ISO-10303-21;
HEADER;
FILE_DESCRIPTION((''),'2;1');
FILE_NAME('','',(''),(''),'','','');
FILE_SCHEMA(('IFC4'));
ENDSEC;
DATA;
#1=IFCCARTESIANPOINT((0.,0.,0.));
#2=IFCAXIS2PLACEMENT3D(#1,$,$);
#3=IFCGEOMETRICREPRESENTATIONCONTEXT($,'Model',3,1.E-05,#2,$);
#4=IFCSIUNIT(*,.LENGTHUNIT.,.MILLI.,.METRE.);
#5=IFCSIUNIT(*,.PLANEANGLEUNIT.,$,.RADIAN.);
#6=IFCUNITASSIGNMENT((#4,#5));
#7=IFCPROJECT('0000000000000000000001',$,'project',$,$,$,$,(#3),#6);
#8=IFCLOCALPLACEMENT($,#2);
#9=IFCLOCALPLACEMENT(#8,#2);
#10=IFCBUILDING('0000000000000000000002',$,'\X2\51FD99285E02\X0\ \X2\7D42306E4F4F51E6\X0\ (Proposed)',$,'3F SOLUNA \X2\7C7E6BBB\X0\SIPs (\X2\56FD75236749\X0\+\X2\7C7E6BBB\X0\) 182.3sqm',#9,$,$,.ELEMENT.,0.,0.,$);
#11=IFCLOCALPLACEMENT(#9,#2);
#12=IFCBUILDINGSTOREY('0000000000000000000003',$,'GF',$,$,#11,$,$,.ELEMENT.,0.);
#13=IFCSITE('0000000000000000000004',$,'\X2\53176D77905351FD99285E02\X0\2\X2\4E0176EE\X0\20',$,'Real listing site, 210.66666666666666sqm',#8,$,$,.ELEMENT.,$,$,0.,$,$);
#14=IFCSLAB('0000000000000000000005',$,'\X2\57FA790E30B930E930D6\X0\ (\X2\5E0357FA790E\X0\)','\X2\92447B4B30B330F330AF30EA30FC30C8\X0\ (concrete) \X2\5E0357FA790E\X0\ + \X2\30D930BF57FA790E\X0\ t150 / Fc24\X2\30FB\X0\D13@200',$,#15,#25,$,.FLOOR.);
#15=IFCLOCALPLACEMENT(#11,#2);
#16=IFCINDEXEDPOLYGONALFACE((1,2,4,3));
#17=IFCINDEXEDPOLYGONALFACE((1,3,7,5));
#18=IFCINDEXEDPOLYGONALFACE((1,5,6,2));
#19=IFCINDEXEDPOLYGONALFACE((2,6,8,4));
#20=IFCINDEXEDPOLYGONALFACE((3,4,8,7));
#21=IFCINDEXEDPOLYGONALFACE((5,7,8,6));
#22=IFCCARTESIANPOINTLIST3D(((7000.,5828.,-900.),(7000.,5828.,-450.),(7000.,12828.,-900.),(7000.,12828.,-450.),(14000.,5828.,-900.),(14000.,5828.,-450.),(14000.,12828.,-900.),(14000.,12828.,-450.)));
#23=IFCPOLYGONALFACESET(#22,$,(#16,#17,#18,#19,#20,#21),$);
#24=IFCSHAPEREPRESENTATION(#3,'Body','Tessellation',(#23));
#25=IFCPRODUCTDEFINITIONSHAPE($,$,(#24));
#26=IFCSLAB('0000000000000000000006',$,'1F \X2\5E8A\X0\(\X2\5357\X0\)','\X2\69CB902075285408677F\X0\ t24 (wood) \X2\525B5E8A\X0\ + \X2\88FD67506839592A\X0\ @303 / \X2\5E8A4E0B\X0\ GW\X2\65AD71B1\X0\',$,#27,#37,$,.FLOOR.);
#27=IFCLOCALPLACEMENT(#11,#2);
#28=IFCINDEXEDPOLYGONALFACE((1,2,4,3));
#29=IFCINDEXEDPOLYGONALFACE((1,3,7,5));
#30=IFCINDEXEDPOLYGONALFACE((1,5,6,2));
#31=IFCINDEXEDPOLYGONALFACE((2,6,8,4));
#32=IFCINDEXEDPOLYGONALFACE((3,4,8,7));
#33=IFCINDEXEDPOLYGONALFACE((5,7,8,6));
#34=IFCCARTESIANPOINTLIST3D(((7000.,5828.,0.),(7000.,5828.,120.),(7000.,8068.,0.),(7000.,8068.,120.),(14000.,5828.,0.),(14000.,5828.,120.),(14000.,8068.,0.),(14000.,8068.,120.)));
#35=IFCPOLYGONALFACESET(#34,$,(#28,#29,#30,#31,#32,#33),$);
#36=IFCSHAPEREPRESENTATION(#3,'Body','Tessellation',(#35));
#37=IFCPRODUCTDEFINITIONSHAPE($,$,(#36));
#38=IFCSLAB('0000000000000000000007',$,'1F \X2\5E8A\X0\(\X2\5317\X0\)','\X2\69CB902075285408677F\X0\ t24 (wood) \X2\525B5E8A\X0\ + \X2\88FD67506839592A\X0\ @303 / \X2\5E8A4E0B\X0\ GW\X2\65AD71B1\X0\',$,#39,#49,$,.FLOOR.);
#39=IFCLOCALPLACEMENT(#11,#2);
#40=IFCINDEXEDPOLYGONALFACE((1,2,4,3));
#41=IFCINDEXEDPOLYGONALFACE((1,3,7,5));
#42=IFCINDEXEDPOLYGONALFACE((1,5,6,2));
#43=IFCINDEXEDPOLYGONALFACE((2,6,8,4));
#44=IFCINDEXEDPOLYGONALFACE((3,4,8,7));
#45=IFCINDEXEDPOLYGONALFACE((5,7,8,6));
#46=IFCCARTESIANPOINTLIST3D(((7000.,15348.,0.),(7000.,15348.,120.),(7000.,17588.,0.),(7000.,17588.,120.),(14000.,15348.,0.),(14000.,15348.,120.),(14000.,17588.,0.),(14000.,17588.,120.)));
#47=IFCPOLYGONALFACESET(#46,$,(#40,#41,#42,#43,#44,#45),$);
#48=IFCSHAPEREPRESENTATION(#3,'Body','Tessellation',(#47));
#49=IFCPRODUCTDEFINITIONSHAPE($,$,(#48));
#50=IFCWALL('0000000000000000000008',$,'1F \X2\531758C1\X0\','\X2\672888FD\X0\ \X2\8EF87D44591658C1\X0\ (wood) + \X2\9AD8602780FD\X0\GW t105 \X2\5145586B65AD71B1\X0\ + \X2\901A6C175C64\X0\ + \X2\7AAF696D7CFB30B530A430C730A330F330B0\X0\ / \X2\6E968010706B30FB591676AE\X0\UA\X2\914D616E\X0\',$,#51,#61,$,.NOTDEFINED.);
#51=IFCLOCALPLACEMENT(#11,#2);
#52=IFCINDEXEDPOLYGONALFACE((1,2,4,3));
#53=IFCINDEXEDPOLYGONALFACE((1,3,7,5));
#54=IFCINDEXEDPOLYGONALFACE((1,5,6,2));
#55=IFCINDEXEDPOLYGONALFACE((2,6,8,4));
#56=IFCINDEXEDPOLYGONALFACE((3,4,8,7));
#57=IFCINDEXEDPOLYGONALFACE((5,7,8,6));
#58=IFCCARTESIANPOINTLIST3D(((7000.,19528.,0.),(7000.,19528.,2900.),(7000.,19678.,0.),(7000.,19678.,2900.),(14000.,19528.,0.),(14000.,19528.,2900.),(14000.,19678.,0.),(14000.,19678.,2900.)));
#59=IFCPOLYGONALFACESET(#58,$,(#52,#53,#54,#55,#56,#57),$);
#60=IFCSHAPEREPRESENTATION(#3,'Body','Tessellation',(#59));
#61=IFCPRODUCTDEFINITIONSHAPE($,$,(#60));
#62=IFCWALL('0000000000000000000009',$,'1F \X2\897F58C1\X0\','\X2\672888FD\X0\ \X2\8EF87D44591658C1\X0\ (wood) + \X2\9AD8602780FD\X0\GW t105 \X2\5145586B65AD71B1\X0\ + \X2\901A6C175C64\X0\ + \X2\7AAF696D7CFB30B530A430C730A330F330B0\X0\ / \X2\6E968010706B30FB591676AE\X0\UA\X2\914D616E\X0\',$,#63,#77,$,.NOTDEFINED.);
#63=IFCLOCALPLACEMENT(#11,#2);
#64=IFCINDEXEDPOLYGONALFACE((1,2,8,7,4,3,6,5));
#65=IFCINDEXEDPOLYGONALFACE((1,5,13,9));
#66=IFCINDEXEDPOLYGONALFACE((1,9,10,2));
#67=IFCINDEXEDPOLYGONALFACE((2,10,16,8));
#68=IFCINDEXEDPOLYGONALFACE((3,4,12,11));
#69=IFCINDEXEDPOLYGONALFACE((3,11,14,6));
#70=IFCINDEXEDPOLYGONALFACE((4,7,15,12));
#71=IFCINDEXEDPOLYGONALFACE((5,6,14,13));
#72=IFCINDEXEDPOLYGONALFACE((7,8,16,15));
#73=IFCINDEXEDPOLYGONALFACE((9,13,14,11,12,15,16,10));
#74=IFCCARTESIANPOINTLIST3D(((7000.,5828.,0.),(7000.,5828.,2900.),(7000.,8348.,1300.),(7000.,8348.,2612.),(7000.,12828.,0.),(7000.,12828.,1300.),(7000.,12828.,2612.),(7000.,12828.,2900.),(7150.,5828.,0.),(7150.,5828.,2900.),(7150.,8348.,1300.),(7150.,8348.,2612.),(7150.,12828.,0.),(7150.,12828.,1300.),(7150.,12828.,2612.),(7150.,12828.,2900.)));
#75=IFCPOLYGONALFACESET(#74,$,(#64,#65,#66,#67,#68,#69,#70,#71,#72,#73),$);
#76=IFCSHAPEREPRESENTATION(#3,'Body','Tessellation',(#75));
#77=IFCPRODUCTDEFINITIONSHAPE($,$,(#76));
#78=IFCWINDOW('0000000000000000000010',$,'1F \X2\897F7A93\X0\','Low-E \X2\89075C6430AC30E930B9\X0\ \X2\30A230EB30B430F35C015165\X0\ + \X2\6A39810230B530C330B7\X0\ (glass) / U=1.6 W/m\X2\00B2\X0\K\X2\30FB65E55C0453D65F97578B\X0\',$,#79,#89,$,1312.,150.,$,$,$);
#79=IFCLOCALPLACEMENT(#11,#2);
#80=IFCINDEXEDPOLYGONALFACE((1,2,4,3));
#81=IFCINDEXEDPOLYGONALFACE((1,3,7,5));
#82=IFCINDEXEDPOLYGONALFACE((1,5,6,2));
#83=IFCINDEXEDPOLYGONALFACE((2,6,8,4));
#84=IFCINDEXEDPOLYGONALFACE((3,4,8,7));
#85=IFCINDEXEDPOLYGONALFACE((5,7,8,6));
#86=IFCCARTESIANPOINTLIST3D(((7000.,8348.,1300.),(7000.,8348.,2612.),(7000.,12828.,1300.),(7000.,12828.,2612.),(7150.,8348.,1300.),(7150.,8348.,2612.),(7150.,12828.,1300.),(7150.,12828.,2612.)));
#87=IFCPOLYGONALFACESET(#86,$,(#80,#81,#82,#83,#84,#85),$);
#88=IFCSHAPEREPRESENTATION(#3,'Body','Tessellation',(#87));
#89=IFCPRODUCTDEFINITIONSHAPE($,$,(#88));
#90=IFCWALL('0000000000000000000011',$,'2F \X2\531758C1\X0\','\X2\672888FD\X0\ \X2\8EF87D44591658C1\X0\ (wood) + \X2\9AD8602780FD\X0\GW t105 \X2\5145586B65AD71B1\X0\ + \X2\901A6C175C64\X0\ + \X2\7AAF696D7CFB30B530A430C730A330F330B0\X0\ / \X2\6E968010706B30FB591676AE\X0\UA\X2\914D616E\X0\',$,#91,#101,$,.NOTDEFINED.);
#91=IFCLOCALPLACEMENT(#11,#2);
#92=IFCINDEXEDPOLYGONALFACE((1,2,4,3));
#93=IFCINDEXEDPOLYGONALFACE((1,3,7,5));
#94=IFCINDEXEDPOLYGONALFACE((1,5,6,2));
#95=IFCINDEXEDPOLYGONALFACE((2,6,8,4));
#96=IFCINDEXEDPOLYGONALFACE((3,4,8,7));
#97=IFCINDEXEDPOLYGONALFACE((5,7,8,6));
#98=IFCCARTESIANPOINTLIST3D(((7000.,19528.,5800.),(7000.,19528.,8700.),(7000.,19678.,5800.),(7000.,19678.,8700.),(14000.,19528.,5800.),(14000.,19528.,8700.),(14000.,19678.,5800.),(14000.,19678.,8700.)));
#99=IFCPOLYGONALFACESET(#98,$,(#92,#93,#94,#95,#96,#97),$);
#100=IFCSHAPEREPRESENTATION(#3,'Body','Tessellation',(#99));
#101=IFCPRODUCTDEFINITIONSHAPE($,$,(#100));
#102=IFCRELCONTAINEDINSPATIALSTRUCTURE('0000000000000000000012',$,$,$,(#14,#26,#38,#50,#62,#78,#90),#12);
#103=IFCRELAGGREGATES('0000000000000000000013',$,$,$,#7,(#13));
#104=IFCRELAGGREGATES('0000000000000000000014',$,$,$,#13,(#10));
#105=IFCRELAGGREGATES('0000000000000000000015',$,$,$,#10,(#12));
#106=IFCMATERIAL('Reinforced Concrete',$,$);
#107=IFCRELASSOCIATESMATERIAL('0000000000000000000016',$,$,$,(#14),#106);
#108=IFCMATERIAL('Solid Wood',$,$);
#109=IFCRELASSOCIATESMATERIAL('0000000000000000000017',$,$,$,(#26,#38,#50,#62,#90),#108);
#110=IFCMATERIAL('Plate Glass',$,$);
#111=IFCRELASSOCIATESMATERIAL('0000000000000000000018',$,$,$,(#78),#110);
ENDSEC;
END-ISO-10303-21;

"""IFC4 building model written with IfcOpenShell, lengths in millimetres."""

from ifc_helpers import new_model, si_unit, frame, frame_2d, origin, place, context, project, spatial, rectangle, extrude, material, element, fill, save


model = new_model("IFC4")

# Units and contexts
model_context = context("Model", 3, precision=1e-05, world=origin())
ifc_project = project(units=[si_unit("LENGTHUNIT", "METRE", prefix="MILLI"), si_unit("PLANEANGLEUNIT", "RADIAN")], contexts=[model_context])

# Site, building, storey
site_placement = place(None, origin())
site = spatial("IfcSite", under=ifc_project, at=site_placement, Name="北海道函館市2丁目20", ObjectType="Real listing site, 210.66666666666666sqm", CompositionType="ELEMENT", RefElevation=0.0)
building_placement = place(site_placement, origin())
building = spatial("IfcBuilding", under=site, at=building_placement, Name="函館市 終の住処 (Proposed)", ObjectType="3F SOLUNA 籾殻SIPs (国産杉+籾殻) 182.3sqm", CompositionType="ELEMENT", ElevationOfRefHeight=0.0, ElevationOfTerrain=0.0)
storey_placement = place(building_placement, origin())
storey = spatial("IfcBuildingStorey", under=building, at=storey_placement, Name="GF", CompositionType="ELEMENT", Elevation=0.0)

# Slabs
ifc_material_1 = material(Name="Reinforced Concrete")
slab_1_placement = place(storey_placement, frame((3500.0, 2914.0, -450.0)))
element("IfcSlab", 1, at=slab_1_placement, inside=storey, material=ifc_material_1, Name="基礎スラブ (布基礎)", Description="鉄筋コンクリート (concrete) 布基礎 + ベタ基礎 t150 / Fc24・D13@200", PredefinedType="FLOOR", context=model_context, shape_type="SweptSolid", body=[
    extrude(rectangle(XDim=7000.0, YDim=7000.0, at=frame_2d((3500.0, 3500.0))), frame((3500.0, 2914.0, -450.0)), (0.0, 0.0, 1.0), 450.0),
])
ifc_material_2 = material(Name="Solid Wood")
slab_2_placement = place(storey_placement, frame((3500.0, 2914.0, 0.0)))
element("IfcSlab", 2, at=slab_2_placement, inside=storey, material=ifc_material_2, Name="1F 床(南)", Description="構造用合板 t24 (wood) 剛床 + 製材根太 @303 / 床下 GW断熱", PredefinedType="FLOOR", context=model_context, shape_type="SweptSolid", body=[
    extrude(rectangle(XDim=7000.0, YDim=2240.0, at=frame_2d((3500.0, 1120.0))), frame((3500.0, 2914.0, 0.0)), (0.0, 0.0, 1.0), 120.0),
])
slab_3_placement = place(storey_placement, frame((3500.0, 7674.0, 0.0)))
element("IfcSlab", 3, at=slab_3_placement, inside=storey, material=ifc_material_2, Name="1F 床(北)", Description="構造用合板 t24 (wood) 剛床 + 製材根太 @303 / 床下 GW断熱", PredefinedType="FLOOR", context=model_context, shape_type="SweptSolid", body=[
    extrude(rectangle(XDim=7000.0, YDim=2240.0, at=frame_2d((3500.0, 1120.0))), frame((3500.0, 7674.0, 0.0)), (0.0, 0.0, 1.0), 120.0),
])

# Shared definitions
ifc_material_3 = material(Name="Plate Glass")

# Wall
wall_1_placement = place(storey_placement, frame((3500.0, 9764.0, 0.0)))
element("IfcWall", 4, at=wall_1_placement, inside=storey, material=ifc_material_2, Name="1F 北壁", Description="木製 軸組外壁 (wood) + 高性能GW t105 充填断熱 + 通気層 + 窯業系サイディング / 準耐火・外皮UA配慮", PredefinedType="NOTDEFINED", context=model_context, shape_type="SweptSolid", body=[
    extrude(rectangle(XDim=7000.0, YDim=150.0, at=frame_2d((3500.0, 75.0))), frame((3500.0, 9764.0, 0.0)), (0.0, 0.0, 1.0), 2900.0),
])

# Wall, opening, window
wall_2_placement = place(storey_placement, frame((3500.0, 2914.0, 0.0)))
wall_2 = element("IfcWall", 5, at=wall_2_placement, inside=storey, material=ifc_material_2, Name="1F 西壁", Description="木製 軸組外壁 (wood) + 高性能GW t105 充填断熱 + 通気層 + 窯業系サイディング / 準耐火・外皮UA配慮", PredefinedType="NOTDEFINED", context=model_context, shape_type="SweptSolid", body=[
    extrude(rectangle(XDim=150.0, YDim=7000.0, at=frame_2d((75.0, 3500.0))), frame((3500.0, 2914.0, 0.0)), (0.0, 0.0, 1.0), 2900.0),
])
opening_1_placement = place(storey_placement, frame((3500.0, 4174.0, 650.0)))
opening_1 = element("IfcOpeningElement", 6, at=opening_1_placement, cuts=wall_2, PredefinedType="NOTDEFINED", context=model_context, shape_type="SweptSolid", body=[
    extrude(rectangle(XDim=150.0, YDim=4480.0, at=frame_2d((75.0, 2240.0))), frame((3500.0, 4174.0, 650.0)), (0.0, 0.0, 1.0), 1312.0),
])
window_1_placement = place(storey_placement, frame((3500.0, 4174.0, 650.0)))
window_1 = element("IfcWindow", 7, at=window_1_placement, inside=storey, material=ifc_material_3, Name="1F 西窓", Description="Low-E 複層ガラス アルゴン封入 + 樹脂サッシ (glass) / U=1.6 W/m²K・日射取得型", OverallHeight=1312.0, OverallWidth=150.0, context=model_context, shape_type="SweptSolid", body=[
    extrude(rectangle(XDim=150.0, YDim=4480.0, at=frame_2d((75.0, 2240.0))), frame((3500.0, 4174.0, 650.0)), (0.0, 0.0, 1.0), 1312.0),
])
fill(opening_1, window_1)

# Wall
wall_3_placement = place(storey_placement, frame((3500.0, 9764.0, 2900.0)))
element("IfcWall", 8, at=wall_3_placement, inside=storey, material=ifc_material_2, Name="2F 北壁", Description="木製 軸組外壁 (wood) + 高性能GW t105 充填断熱 + 通気層 + 窯業系サイディング / 準耐火・外皮UA配慮", PredefinedType="NOTDEFINED", context=model_context, shape_type="SweptSolid", body=[
    extrude(rectangle(XDim=7000.0, YDim=150.0, at=frame_2d((3500.0, 75.0))), frame((3500.0, 9764.0, 2900.0)), (0.0, 0.0, 1.0), 2900.0),
])

save(model, "model.ifc")
